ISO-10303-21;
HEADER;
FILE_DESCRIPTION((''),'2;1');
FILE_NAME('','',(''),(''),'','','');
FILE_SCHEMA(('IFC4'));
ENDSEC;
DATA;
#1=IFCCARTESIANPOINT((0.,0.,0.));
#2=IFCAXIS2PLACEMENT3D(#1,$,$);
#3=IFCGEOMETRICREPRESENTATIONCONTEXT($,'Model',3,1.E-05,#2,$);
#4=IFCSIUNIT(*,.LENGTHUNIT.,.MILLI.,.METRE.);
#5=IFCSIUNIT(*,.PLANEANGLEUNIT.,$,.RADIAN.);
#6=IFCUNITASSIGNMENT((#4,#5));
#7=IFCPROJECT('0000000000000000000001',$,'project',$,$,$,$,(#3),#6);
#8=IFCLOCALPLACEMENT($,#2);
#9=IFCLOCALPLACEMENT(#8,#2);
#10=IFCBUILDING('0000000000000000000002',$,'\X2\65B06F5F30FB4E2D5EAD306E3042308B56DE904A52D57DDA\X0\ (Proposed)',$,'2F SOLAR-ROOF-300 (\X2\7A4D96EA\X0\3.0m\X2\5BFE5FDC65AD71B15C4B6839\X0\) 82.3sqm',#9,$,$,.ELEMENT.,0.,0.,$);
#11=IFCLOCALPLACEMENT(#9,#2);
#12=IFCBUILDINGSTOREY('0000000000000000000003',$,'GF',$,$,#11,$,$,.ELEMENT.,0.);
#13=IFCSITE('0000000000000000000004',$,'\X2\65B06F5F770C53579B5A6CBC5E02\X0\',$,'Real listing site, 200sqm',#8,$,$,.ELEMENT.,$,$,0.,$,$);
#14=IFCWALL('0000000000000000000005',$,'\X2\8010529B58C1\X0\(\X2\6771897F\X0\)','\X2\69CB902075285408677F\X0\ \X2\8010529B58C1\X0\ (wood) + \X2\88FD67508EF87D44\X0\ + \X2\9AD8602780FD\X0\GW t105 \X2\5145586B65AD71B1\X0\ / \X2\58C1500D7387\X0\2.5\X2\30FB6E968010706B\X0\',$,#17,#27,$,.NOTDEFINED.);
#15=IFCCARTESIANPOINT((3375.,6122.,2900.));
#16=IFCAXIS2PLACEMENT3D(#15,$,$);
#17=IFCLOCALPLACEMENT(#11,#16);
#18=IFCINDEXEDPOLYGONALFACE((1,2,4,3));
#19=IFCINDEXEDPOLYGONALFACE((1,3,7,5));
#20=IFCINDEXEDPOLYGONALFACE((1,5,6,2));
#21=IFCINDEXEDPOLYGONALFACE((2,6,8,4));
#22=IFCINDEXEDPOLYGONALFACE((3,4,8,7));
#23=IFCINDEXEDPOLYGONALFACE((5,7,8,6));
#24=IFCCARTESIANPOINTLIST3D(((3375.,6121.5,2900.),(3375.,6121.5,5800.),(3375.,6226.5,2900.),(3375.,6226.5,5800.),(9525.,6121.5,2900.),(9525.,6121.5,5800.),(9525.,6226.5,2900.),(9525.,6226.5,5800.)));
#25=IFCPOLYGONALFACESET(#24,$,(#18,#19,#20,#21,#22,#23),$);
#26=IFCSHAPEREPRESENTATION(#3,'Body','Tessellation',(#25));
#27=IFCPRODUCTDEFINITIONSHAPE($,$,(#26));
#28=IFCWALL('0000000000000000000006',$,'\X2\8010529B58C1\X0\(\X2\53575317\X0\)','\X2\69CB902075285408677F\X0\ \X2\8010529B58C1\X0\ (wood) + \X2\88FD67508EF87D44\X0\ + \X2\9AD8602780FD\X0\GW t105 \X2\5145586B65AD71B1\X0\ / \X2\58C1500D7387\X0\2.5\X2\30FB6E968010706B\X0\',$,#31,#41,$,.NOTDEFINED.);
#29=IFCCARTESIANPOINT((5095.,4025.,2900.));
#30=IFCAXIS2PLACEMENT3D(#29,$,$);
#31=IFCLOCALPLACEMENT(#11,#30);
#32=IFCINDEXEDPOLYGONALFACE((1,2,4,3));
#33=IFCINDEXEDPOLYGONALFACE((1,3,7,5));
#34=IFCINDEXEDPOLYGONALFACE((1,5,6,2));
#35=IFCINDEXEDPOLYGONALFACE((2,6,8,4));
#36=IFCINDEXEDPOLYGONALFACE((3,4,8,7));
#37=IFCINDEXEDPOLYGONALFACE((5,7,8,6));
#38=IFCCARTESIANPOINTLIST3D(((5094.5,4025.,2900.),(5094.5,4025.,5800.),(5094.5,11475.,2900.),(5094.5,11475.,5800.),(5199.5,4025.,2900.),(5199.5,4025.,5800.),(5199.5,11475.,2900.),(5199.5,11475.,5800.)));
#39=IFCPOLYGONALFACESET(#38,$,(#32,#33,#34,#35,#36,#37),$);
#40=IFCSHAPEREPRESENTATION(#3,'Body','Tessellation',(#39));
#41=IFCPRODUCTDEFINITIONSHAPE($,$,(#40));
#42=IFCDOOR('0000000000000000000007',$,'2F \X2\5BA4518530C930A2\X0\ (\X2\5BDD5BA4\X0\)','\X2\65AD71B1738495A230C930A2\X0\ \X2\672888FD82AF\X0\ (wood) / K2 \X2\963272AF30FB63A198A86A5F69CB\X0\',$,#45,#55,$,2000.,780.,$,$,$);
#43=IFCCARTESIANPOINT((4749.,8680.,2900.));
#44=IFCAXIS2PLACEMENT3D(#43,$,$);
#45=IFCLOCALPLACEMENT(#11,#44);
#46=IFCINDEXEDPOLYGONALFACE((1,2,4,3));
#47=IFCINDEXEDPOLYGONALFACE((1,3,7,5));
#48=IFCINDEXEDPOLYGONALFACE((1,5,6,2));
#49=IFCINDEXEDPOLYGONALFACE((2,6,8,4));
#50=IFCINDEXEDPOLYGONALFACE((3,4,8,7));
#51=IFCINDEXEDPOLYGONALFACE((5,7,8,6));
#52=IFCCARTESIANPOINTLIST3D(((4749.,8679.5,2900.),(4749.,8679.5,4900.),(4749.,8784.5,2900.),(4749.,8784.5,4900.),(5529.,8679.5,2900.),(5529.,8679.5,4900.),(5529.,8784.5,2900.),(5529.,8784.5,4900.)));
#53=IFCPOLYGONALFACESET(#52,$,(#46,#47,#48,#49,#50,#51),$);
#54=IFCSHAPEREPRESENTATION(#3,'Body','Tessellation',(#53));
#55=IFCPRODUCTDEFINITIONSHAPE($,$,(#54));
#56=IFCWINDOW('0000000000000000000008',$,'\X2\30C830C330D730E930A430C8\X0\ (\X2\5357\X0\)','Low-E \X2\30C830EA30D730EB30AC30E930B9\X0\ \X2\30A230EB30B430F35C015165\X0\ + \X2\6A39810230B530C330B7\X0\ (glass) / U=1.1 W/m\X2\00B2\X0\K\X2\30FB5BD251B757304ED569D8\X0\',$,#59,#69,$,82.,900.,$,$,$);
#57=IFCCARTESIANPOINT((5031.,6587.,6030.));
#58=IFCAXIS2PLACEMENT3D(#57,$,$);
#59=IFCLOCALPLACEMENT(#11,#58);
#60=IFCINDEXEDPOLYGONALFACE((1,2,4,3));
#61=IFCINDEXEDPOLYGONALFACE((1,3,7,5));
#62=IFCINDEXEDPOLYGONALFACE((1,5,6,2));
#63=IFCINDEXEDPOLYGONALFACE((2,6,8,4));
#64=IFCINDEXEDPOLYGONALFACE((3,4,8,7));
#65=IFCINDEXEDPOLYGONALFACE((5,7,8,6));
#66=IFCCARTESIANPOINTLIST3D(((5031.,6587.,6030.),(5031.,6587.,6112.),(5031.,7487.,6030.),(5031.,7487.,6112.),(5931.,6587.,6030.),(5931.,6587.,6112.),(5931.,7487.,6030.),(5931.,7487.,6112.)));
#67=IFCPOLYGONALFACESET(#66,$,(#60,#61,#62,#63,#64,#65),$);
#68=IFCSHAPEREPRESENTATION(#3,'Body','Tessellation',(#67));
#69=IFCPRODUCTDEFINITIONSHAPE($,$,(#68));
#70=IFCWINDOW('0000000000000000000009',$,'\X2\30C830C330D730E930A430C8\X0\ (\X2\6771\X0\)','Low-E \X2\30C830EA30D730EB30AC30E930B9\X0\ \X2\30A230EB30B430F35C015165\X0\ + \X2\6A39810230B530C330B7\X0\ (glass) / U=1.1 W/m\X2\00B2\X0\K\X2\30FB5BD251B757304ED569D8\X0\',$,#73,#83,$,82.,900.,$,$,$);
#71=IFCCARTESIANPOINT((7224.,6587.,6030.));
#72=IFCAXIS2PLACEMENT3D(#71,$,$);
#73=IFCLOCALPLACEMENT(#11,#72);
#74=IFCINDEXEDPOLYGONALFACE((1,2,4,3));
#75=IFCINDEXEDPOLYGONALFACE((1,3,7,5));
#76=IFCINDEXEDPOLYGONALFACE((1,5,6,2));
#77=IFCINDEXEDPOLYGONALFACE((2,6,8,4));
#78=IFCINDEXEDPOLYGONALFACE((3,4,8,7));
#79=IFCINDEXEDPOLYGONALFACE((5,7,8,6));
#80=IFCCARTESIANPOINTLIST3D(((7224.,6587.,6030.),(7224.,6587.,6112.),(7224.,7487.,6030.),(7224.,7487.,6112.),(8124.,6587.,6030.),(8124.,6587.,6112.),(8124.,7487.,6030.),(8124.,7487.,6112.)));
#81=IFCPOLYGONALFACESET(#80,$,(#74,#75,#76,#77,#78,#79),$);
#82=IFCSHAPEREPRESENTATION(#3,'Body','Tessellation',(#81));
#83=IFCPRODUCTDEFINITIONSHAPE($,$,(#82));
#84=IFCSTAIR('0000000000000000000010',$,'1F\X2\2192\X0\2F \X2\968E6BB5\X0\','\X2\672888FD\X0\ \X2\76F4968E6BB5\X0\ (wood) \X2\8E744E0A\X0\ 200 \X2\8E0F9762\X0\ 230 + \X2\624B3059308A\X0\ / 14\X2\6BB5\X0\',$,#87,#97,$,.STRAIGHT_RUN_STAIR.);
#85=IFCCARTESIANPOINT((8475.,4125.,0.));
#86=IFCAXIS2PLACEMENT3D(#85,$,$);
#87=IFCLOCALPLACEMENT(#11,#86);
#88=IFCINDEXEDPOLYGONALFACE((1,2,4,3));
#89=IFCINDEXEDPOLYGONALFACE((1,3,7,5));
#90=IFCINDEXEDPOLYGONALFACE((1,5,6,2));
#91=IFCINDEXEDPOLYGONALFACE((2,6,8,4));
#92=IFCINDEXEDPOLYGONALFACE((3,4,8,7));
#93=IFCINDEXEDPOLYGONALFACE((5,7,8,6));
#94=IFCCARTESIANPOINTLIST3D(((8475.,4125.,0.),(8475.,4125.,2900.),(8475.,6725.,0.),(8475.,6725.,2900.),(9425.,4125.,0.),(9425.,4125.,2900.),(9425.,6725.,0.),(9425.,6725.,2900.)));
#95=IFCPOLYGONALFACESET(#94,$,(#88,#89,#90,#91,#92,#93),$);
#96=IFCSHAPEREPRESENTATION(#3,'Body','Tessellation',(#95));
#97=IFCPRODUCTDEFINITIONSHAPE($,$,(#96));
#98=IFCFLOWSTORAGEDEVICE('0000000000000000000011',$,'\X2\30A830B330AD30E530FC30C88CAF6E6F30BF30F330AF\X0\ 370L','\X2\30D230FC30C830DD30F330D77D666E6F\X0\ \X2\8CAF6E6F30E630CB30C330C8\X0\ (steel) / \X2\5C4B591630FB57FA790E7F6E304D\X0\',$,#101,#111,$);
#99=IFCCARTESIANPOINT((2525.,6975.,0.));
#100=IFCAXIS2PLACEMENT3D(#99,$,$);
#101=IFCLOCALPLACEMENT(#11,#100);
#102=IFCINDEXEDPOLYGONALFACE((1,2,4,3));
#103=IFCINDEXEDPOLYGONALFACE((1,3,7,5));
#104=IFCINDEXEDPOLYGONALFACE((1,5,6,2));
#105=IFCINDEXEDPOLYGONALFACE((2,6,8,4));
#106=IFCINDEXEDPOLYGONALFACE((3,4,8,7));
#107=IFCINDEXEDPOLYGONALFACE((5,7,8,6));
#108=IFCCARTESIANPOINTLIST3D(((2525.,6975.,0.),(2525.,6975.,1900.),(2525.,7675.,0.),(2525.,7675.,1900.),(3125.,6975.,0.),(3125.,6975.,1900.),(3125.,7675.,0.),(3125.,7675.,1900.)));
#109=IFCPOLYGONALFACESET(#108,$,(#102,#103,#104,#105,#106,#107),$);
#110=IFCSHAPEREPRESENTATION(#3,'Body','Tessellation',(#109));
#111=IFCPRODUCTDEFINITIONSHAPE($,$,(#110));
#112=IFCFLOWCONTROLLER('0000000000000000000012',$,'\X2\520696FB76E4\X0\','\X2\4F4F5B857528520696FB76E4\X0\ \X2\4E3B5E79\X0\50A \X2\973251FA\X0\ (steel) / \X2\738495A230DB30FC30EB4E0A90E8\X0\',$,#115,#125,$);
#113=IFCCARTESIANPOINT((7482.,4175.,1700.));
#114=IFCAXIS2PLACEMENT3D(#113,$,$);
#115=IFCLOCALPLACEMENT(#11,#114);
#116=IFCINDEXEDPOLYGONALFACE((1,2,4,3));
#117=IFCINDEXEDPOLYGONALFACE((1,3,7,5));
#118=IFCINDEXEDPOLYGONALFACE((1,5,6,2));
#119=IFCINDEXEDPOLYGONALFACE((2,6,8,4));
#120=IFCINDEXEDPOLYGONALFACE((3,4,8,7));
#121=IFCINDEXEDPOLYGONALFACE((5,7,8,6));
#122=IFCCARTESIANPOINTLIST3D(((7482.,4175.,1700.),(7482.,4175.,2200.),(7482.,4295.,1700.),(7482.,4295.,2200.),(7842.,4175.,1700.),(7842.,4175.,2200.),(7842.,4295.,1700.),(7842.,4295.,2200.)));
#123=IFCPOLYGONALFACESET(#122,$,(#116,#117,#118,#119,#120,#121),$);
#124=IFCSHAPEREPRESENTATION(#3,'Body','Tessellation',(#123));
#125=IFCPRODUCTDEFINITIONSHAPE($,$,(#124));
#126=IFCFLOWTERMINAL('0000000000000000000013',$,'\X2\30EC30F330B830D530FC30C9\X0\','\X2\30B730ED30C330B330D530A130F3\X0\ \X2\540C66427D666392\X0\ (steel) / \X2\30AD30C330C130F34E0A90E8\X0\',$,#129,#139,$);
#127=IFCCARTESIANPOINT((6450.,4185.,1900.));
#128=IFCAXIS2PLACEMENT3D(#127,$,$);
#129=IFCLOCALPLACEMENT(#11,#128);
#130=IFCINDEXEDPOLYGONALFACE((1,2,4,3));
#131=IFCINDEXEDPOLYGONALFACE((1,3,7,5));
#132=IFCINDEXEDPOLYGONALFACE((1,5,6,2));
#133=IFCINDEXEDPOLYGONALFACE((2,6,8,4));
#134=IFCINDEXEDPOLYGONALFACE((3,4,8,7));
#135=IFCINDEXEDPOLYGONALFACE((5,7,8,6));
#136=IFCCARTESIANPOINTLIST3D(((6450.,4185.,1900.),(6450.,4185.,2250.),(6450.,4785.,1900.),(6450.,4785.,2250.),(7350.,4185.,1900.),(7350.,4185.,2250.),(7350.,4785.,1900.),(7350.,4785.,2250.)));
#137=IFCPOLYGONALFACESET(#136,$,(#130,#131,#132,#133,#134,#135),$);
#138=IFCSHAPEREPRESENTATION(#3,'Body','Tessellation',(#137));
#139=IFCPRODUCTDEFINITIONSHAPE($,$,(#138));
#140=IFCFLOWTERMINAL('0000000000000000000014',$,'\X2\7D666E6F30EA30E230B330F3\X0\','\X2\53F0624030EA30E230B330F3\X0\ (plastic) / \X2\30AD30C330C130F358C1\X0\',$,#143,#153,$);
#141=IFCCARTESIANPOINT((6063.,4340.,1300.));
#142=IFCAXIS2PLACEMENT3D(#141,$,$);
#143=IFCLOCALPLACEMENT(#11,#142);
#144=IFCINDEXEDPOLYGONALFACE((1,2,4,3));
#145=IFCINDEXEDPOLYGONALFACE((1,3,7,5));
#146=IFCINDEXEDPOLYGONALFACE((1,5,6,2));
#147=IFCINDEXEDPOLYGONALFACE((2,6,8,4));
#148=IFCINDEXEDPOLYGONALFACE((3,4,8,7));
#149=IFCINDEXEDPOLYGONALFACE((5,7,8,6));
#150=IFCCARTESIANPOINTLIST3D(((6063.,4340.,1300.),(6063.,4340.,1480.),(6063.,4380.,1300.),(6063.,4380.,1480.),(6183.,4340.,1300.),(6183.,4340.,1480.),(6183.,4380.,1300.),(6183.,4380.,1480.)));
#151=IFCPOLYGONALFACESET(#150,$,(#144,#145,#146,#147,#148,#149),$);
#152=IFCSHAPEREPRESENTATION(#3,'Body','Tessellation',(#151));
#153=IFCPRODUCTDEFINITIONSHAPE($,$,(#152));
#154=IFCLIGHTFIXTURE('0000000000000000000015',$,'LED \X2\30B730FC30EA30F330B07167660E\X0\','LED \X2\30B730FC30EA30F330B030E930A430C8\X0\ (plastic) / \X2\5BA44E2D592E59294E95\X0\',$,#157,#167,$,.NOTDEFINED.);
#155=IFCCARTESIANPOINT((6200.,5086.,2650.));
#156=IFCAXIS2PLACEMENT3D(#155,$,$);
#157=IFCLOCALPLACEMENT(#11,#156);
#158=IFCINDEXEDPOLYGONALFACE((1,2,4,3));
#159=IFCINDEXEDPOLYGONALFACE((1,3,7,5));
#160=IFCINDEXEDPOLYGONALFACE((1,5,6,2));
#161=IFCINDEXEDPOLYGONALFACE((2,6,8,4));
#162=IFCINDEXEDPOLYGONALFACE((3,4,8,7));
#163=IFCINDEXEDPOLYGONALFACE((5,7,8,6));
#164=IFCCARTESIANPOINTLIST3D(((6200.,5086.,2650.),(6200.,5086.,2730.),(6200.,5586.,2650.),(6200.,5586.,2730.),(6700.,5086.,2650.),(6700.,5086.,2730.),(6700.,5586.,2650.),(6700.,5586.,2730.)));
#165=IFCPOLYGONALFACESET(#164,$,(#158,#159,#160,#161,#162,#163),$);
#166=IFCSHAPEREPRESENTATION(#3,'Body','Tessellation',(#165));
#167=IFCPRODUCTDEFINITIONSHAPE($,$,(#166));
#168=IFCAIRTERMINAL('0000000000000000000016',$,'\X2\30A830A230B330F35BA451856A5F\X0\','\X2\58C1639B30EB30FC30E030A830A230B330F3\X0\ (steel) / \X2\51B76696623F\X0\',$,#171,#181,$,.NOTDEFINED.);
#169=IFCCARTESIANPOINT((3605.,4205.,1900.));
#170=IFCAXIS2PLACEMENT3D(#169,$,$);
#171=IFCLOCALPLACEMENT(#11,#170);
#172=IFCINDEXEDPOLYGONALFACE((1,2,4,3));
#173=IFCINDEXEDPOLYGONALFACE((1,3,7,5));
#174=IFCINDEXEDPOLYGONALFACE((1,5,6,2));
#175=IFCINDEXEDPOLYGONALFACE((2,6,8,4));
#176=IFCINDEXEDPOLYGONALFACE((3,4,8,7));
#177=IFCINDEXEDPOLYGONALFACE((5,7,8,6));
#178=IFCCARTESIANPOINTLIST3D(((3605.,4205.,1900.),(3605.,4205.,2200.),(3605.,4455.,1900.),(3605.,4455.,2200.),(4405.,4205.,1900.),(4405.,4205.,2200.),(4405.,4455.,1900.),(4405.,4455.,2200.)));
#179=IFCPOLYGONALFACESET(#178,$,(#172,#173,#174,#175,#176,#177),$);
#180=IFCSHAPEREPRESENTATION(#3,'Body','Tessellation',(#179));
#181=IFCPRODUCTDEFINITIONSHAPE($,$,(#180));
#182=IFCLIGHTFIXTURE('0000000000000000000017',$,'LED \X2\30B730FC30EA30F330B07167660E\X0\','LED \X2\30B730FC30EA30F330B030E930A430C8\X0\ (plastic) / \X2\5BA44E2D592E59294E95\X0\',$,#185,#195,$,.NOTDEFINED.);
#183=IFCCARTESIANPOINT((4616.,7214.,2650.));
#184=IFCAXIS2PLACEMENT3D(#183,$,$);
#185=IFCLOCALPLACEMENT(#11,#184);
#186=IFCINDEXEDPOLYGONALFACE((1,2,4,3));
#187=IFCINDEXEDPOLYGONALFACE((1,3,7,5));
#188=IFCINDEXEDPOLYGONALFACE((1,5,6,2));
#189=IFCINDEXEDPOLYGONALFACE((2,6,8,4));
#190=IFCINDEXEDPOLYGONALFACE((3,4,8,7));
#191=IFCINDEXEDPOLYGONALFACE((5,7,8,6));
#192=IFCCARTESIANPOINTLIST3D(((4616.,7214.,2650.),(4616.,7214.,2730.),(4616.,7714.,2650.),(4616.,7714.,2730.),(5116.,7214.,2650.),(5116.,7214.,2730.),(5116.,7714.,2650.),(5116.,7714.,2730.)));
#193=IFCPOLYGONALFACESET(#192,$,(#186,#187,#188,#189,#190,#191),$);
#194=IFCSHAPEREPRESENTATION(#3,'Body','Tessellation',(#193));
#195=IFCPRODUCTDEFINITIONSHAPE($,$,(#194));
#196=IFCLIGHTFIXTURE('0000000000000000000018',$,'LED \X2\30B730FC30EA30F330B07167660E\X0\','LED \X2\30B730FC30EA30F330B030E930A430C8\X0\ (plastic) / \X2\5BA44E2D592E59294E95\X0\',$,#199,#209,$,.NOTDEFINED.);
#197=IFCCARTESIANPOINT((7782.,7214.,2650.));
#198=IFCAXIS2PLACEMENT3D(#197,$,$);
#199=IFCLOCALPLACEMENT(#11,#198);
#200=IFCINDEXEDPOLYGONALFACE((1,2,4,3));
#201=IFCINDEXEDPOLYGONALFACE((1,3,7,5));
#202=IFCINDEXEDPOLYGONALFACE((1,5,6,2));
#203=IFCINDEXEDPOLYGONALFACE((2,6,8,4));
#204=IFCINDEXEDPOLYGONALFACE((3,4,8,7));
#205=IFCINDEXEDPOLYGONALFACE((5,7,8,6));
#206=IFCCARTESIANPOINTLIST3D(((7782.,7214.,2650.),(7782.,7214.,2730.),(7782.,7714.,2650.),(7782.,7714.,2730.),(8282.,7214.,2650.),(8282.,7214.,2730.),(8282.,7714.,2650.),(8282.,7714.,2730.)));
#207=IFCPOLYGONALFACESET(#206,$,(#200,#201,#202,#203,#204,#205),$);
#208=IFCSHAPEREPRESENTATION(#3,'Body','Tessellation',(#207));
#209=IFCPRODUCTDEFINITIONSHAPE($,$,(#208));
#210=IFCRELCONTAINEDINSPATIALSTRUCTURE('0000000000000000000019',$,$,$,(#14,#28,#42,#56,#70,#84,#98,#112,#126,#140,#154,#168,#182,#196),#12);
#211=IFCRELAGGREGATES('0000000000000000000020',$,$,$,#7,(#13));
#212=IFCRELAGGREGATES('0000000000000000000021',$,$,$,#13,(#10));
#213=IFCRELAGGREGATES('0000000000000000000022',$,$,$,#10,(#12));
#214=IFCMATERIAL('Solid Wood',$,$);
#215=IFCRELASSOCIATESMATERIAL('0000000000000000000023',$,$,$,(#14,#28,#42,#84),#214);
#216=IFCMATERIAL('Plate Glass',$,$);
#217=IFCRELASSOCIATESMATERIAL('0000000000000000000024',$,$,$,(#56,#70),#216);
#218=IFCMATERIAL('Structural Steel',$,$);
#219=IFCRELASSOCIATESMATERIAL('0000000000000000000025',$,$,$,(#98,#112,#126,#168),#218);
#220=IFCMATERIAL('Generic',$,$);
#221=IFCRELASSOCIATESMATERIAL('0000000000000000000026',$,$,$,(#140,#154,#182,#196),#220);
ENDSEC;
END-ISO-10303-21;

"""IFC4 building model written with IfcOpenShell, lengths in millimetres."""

from ifc_helpers import new_model, si_unit, frame, frame_2d, origin, place, context, project, spatial, rectangle, extrude, material, element, fill, save


model = new_model("IFC4")

# Units and contexts
model_context = context("Model", 3, precision=1e-05, world=origin())
ifc_project = project(units=[si_unit("LENGTHUNIT", "METRE", prefix="MILLI"), si_unit("PLANEANGLEUNIT", "RADIAN")], contexts=[model_context])

# Site, building, storey
site_placement = place(None, origin())
site = spatial("IfcSite", under=ifc_project, at=site_placement, Name="新潟県南魚沼市", ObjectType="Real listing site, 200sqm", CompositionType="ELEMENT", RefElevation=0.0)
building_placement = place(site_placement, origin())
building = spatial("IfcBuilding", under=site, at=building_placement, Name="新潟・中庭のある回遊動線 (Proposed)", ObjectType="2F SOLAR-ROOF-300 (積雪3.0m対応断熱屋根) 82.3sqm", CompositionType="ELEMENT", ElevationOfRefHeight=0.0, ElevationOfTerrain=0.0)
storey_placement = place(building_placement, origin())
storey = spatial("IfcBuildingStorey", under=building, at=storey_placement, Name="GF", CompositionType="ELEMENT", Elevation=0.0)

# Shared definitions
ifc_material_1 = material(Name="Solid Wood")

# Wall
wall_1_placement = place(storey_placement, frame((3375.0, 6122.0, 2900.0)))
element("IfcWall", 1, at=wall_1_placement, inside=storey, material=ifc_material_1, Name="耐力壁(東西)", Description="構造用合板 耐力壁 (wood) + 製材軸組 + 高性能GW t105 充填断熱 / 壁倍率2.5・準耐火", PredefinedType="NOTDEFINED", context=model_context, shape_type="SweptSolid", body=[
    extrude(rectangle(XDim=6150.0, YDim=105.0, at=frame_2d((3075.0, 52.0))), frame((3375.0, 6122.0, 2900.0)), (0.0, 0.0, 1.0), 2900.0),
])

# Wall, opening, door
wall_2_placement = place(storey_placement, frame((5095.0, 4025.0, 2900.0)))
wall_2 = element("IfcWall", 2, at=wall_2_placement, inside=storey, material=ifc_material_1, Name="耐力壁(南北)", Description="構造用合板 耐力壁 (wood) + 製材軸組 + 高性能GW t105 充填断熱 / 壁倍率2.5・準耐火", PredefinedType="NOTDEFINED", context=model_context, shape_type="SweptSolid", body=[
    extrude(rectangle(XDim=105.0, YDim=7450.0, at=frame_2d((52.0, 3725.0))), frame((5095.0, 4025.0, 2900.0)), (0.0, 0.0, 1.0), 2900.0),
])
opening_placement = place(storey_placement, frame((4749.0, 8680.0, 2900.0)))
opening = element("IfcOpeningElement", 3, at=opening_placement, cuts=wall_2, PredefinedType="NOTDEFINED", context=model_context, shape_type="SweptSolid", body=[
    extrude(rectangle(XDim=780.0, YDim=105.0, at=frame_2d((390.0, 52.0))), frame((4749.0, 8680.0, 2900.0)), (0.0, 0.0, 1.0), 2000.0),
])
door_placement = place(storey_placement, frame((4749.0, 8680.0, 2900.0)))
door = element("IfcDoor", 4, at=door_placement, inside=storey, material=ifc_material_1, Name="2F 室内ドア (寝室)", Description="断熱玄関ドア 木製芯 (wood) / K2 防犯・採風機構", OverallHeight=2000.0, OverallWidth=780.0, context=model_context, shape_type="SweptSolid", body=[
    extrude(rectangle(XDim=780.0, YDim=105.0, at=frame_2d((390.0, 52.0))), frame((4749.0, 8680.0, 2900.0)), (0.0, 0.0, 1.0), 2000.0),
])
fill(opening, door)

# Windows
ifc_material_2 = material(Name="Plate Glass")
window_1_placement = place(storey_placement, frame((5031.0, 6587.0, 6030.0)))
element("IfcWindow", 5, at=window_1_placement, inside=storey, material=ifc_material_2, Name="トップライト (南)", Description="Low-E トリプルガラス アルゴン封入 + 樹脂サッシ (glass) / U=1.1 W/m²K・寒冷地仕様", OverallHeight=82.0, OverallWidth=900.0, context=model_context, shape_type="SweptSolid", body=[
    extrude(rectangle(XDim=900.0, YDim=900.0, at=frame_2d((450.0, 450.0))), frame((5031.0, 6587.0, 6030.0)), (0.0, 0.0, 1.0), 82.0),
])
window_2_placement = place(storey_placement, frame((7224.0, 6587.0, 6030.0)))
element("IfcWindow", 6, at=window_2_placement, inside=storey, material=ifc_material_2, Name="トップライト (東)", Description="Low-E トリプルガラス アルゴン封入 + 樹脂サッシ (glass) / U=1.1 W/m²K・寒冷地仕様", OverallHeight=82.0, OverallWidth=900.0, context=model_context, shape_type="SweptSolid", body=[
    extrude(rectangle(XDim=900.0, YDim=900.0, at=frame_2d((450.0, 450.0))), frame((7224.0, 6587.0, 6030.0)), (0.0, 0.0, 1.0), 82.0),
])

# Stair
stair_placement = place(storey_placement, frame((8475.0, 4125.0, 0.0)))
element("IfcStair", 7, at=stair_placement, inside=storey, material=ifc_material_1, Name="1F→2F 階段", Description="木製 直階段 (wood) 蹴上 200 踏面 230 + 手すり / 14段", PredefinedType="STRAIGHT_RUN_STAIR", context=model_context, shape_type="SweptSolid", body=[
    extrude(rectangle(XDim=950.0, YDim=2600.0, at=frame_2d((475.0, 1300.0))), frame((8475.0, 4125.0, 0.0)), (0.0, 0.0, 1.0), 2900.0),
])

# Flow storage device
ifc_material_3 = material(Name="Structural Steel")
flow_storage_device_placement = place(storey_placement, frame((2525.0, 6975.0, 0.0)))
element("IfcFlowStorageDevice", 8, at=flow_storage_device_placement, inside=storey, material=ifc_material_3, Name="エコキュート貯湯タンク 370L", Description="ヒートポンプ給湯 貯湯ユニット (steel) / 屋外・基礎置き", context=model_context, shape_type="SweptSolid", body=[
    extrude(rectangle(XDim=600.0, YDim=700.0, at=frame_2d((300.0, 350.0))), frame((2525.0, 6975.0, 0.0)), (0.0, 0.0, 1.0), 1900.0),
])

# Flow controller
flow_controller_placement = place(storey_placement, frame((7482.0, 4175.0, 1700.0)))
element("IfcFlowController", 9, at=flow_controller_placement, inside=storey, material=ifc_material_3, Name="分電盤", Description="住宅用分電盤 主幹50A 露出 (steel) / 玄関ホール上部", context=model_context, shape_type="SweptSolid", body=[
    extrude(rectangle(XDim=360.0, YDim=120.0, at=frame_2d((180.0, 60.0))), frame((7482.0, 4175.0, 1700.0)), (0.0, 0.0, 1.0), 500.0),
])

# Flow terminals
flow_terminal_1_placement = place(storey_placement, frame((6450.0, 4185.0, 1900.0)))
element("IfcFlowTerminal", 10, at=flow_terminal_1_placement, inside=storey, material=ifc_material_3, Name="レンジフード", Description="シロッコファン 同時給排 (steel) / キッチン上部", context=model_context, shape_type="SweptSolid", body=[
    extrude(rectangle(XDim=900.0, YDim=600.0, at=frame_2d((450.0, 300.0))), frame((6450.0, 4185.0, 1900.0)), (0.0, 0.0, 1.0), 350.0),
])
ifc_material_4 = material(Name="Generic")
flow_terminal_2_placement = place(storey_placement, frame((6063.0, 4340.0, 1300.0)))
element("IfcFlowTerminal", 11, at=flow_terminal_2_placement, inside=storey, material=ifc_material_4, Name="給湯リモコン", Description="台所リモコン (plastic) / キッチン壁", context=model_context, shape_type="SweptSolid", body=[
    extrude(rectangle(XDim=120.0, YDim=40.0, at=frame_2d((60.0, 20.0))), frame((6063.0, 4340.0, 1300.0)), (0.0, 0.0, 1.0), 180.0),
])

# Light fixture
light_fixture_1_placement = place(storey_placement, frame((6200.0, 5086.0, 2650.0)))
element("IfcLightFixture", 12, at=light_fixture_1_placement, inside=storey, material=ifc_material_4, Name="LED シーリング照明", Description="LED シーリングライト (plastic) / 室中央天井", PredefinedType="NOTDEFINED", context=model_context, shape_type="SweptSolid", body=[
    extrude(rectangle(XDim=500.0, YDim=500.0, at=frame_2d((250.0, 250.0))), frame((6200.0, 5086.0, 2650.0)), (0.0, 0.0, 1.0), 80.0),
])

# Air terminal
air_terminal_1_placement = place(storey_placement, frame((3605.0, 4205.0, 1900.0)))
element("IfcAirTerminal", 13, at=air_terminal_1_placement, inside=storey, material=ifc_material_3, Name="エアコン室内機", Description="壁掛ルームエアコン (steel) / 冷暖房", PredefinedType="NOTDEFINED", context=model_context, shape_type="SweptSolid", body=[
    extrude(rectangle(XDim=800.0, YDim=250.0, at=frame_2d((400.0, 125.0))), frame((3605.0, 4205.0, 1900.0)), (0.0, 0.0, 1.0), 300.0),
])

# Light fixtures
light_fixture_2_placement = place(storey_placement, frame((4616.0, 7214.0, 2650.0)))
element("IfcLightFixture", 14, at=light_fixture_2_placement, inside=storey, material=ifc_material_4, Name="LED シーリング照明", Description="LED シーリングライト (plastic) / 室中央天井", PredefinedType="NOTDEFINED", context=model_context, shape_type="SweptSolid", body=[
    extrude(rectangle(XDim=500.0, YDim=500.0, at=frame_2d((250.0, 250.0))), frame((4616.0, 7214.0, 2650.0)), (0.0, 0.0, 1.0), 80.0),
])
light_fixture_3_placement = place(storey_placement, frame((7782.0, 7214.0, 2650.0)))
element("IfcLightFixture", 15, at=light_fixture_3_placement, inside=storey, material=ifc_material_4, Name="LED シーリング照明", Description="LED シーリングライト (plastic) / 室中央天井", PredefinedType="NOTDEFINED", context=model_context, shape_type="SweptSolid", body=[
    extrude(rectangle(XDim=500.0, YDim=500.0, at=frame_2d((250.0, 250.0))), frame((7782.0, 7214.0, 2650.0)), (0.0, 0.0, 1.0), 80.0),
])

save(model, "model.ifc")
